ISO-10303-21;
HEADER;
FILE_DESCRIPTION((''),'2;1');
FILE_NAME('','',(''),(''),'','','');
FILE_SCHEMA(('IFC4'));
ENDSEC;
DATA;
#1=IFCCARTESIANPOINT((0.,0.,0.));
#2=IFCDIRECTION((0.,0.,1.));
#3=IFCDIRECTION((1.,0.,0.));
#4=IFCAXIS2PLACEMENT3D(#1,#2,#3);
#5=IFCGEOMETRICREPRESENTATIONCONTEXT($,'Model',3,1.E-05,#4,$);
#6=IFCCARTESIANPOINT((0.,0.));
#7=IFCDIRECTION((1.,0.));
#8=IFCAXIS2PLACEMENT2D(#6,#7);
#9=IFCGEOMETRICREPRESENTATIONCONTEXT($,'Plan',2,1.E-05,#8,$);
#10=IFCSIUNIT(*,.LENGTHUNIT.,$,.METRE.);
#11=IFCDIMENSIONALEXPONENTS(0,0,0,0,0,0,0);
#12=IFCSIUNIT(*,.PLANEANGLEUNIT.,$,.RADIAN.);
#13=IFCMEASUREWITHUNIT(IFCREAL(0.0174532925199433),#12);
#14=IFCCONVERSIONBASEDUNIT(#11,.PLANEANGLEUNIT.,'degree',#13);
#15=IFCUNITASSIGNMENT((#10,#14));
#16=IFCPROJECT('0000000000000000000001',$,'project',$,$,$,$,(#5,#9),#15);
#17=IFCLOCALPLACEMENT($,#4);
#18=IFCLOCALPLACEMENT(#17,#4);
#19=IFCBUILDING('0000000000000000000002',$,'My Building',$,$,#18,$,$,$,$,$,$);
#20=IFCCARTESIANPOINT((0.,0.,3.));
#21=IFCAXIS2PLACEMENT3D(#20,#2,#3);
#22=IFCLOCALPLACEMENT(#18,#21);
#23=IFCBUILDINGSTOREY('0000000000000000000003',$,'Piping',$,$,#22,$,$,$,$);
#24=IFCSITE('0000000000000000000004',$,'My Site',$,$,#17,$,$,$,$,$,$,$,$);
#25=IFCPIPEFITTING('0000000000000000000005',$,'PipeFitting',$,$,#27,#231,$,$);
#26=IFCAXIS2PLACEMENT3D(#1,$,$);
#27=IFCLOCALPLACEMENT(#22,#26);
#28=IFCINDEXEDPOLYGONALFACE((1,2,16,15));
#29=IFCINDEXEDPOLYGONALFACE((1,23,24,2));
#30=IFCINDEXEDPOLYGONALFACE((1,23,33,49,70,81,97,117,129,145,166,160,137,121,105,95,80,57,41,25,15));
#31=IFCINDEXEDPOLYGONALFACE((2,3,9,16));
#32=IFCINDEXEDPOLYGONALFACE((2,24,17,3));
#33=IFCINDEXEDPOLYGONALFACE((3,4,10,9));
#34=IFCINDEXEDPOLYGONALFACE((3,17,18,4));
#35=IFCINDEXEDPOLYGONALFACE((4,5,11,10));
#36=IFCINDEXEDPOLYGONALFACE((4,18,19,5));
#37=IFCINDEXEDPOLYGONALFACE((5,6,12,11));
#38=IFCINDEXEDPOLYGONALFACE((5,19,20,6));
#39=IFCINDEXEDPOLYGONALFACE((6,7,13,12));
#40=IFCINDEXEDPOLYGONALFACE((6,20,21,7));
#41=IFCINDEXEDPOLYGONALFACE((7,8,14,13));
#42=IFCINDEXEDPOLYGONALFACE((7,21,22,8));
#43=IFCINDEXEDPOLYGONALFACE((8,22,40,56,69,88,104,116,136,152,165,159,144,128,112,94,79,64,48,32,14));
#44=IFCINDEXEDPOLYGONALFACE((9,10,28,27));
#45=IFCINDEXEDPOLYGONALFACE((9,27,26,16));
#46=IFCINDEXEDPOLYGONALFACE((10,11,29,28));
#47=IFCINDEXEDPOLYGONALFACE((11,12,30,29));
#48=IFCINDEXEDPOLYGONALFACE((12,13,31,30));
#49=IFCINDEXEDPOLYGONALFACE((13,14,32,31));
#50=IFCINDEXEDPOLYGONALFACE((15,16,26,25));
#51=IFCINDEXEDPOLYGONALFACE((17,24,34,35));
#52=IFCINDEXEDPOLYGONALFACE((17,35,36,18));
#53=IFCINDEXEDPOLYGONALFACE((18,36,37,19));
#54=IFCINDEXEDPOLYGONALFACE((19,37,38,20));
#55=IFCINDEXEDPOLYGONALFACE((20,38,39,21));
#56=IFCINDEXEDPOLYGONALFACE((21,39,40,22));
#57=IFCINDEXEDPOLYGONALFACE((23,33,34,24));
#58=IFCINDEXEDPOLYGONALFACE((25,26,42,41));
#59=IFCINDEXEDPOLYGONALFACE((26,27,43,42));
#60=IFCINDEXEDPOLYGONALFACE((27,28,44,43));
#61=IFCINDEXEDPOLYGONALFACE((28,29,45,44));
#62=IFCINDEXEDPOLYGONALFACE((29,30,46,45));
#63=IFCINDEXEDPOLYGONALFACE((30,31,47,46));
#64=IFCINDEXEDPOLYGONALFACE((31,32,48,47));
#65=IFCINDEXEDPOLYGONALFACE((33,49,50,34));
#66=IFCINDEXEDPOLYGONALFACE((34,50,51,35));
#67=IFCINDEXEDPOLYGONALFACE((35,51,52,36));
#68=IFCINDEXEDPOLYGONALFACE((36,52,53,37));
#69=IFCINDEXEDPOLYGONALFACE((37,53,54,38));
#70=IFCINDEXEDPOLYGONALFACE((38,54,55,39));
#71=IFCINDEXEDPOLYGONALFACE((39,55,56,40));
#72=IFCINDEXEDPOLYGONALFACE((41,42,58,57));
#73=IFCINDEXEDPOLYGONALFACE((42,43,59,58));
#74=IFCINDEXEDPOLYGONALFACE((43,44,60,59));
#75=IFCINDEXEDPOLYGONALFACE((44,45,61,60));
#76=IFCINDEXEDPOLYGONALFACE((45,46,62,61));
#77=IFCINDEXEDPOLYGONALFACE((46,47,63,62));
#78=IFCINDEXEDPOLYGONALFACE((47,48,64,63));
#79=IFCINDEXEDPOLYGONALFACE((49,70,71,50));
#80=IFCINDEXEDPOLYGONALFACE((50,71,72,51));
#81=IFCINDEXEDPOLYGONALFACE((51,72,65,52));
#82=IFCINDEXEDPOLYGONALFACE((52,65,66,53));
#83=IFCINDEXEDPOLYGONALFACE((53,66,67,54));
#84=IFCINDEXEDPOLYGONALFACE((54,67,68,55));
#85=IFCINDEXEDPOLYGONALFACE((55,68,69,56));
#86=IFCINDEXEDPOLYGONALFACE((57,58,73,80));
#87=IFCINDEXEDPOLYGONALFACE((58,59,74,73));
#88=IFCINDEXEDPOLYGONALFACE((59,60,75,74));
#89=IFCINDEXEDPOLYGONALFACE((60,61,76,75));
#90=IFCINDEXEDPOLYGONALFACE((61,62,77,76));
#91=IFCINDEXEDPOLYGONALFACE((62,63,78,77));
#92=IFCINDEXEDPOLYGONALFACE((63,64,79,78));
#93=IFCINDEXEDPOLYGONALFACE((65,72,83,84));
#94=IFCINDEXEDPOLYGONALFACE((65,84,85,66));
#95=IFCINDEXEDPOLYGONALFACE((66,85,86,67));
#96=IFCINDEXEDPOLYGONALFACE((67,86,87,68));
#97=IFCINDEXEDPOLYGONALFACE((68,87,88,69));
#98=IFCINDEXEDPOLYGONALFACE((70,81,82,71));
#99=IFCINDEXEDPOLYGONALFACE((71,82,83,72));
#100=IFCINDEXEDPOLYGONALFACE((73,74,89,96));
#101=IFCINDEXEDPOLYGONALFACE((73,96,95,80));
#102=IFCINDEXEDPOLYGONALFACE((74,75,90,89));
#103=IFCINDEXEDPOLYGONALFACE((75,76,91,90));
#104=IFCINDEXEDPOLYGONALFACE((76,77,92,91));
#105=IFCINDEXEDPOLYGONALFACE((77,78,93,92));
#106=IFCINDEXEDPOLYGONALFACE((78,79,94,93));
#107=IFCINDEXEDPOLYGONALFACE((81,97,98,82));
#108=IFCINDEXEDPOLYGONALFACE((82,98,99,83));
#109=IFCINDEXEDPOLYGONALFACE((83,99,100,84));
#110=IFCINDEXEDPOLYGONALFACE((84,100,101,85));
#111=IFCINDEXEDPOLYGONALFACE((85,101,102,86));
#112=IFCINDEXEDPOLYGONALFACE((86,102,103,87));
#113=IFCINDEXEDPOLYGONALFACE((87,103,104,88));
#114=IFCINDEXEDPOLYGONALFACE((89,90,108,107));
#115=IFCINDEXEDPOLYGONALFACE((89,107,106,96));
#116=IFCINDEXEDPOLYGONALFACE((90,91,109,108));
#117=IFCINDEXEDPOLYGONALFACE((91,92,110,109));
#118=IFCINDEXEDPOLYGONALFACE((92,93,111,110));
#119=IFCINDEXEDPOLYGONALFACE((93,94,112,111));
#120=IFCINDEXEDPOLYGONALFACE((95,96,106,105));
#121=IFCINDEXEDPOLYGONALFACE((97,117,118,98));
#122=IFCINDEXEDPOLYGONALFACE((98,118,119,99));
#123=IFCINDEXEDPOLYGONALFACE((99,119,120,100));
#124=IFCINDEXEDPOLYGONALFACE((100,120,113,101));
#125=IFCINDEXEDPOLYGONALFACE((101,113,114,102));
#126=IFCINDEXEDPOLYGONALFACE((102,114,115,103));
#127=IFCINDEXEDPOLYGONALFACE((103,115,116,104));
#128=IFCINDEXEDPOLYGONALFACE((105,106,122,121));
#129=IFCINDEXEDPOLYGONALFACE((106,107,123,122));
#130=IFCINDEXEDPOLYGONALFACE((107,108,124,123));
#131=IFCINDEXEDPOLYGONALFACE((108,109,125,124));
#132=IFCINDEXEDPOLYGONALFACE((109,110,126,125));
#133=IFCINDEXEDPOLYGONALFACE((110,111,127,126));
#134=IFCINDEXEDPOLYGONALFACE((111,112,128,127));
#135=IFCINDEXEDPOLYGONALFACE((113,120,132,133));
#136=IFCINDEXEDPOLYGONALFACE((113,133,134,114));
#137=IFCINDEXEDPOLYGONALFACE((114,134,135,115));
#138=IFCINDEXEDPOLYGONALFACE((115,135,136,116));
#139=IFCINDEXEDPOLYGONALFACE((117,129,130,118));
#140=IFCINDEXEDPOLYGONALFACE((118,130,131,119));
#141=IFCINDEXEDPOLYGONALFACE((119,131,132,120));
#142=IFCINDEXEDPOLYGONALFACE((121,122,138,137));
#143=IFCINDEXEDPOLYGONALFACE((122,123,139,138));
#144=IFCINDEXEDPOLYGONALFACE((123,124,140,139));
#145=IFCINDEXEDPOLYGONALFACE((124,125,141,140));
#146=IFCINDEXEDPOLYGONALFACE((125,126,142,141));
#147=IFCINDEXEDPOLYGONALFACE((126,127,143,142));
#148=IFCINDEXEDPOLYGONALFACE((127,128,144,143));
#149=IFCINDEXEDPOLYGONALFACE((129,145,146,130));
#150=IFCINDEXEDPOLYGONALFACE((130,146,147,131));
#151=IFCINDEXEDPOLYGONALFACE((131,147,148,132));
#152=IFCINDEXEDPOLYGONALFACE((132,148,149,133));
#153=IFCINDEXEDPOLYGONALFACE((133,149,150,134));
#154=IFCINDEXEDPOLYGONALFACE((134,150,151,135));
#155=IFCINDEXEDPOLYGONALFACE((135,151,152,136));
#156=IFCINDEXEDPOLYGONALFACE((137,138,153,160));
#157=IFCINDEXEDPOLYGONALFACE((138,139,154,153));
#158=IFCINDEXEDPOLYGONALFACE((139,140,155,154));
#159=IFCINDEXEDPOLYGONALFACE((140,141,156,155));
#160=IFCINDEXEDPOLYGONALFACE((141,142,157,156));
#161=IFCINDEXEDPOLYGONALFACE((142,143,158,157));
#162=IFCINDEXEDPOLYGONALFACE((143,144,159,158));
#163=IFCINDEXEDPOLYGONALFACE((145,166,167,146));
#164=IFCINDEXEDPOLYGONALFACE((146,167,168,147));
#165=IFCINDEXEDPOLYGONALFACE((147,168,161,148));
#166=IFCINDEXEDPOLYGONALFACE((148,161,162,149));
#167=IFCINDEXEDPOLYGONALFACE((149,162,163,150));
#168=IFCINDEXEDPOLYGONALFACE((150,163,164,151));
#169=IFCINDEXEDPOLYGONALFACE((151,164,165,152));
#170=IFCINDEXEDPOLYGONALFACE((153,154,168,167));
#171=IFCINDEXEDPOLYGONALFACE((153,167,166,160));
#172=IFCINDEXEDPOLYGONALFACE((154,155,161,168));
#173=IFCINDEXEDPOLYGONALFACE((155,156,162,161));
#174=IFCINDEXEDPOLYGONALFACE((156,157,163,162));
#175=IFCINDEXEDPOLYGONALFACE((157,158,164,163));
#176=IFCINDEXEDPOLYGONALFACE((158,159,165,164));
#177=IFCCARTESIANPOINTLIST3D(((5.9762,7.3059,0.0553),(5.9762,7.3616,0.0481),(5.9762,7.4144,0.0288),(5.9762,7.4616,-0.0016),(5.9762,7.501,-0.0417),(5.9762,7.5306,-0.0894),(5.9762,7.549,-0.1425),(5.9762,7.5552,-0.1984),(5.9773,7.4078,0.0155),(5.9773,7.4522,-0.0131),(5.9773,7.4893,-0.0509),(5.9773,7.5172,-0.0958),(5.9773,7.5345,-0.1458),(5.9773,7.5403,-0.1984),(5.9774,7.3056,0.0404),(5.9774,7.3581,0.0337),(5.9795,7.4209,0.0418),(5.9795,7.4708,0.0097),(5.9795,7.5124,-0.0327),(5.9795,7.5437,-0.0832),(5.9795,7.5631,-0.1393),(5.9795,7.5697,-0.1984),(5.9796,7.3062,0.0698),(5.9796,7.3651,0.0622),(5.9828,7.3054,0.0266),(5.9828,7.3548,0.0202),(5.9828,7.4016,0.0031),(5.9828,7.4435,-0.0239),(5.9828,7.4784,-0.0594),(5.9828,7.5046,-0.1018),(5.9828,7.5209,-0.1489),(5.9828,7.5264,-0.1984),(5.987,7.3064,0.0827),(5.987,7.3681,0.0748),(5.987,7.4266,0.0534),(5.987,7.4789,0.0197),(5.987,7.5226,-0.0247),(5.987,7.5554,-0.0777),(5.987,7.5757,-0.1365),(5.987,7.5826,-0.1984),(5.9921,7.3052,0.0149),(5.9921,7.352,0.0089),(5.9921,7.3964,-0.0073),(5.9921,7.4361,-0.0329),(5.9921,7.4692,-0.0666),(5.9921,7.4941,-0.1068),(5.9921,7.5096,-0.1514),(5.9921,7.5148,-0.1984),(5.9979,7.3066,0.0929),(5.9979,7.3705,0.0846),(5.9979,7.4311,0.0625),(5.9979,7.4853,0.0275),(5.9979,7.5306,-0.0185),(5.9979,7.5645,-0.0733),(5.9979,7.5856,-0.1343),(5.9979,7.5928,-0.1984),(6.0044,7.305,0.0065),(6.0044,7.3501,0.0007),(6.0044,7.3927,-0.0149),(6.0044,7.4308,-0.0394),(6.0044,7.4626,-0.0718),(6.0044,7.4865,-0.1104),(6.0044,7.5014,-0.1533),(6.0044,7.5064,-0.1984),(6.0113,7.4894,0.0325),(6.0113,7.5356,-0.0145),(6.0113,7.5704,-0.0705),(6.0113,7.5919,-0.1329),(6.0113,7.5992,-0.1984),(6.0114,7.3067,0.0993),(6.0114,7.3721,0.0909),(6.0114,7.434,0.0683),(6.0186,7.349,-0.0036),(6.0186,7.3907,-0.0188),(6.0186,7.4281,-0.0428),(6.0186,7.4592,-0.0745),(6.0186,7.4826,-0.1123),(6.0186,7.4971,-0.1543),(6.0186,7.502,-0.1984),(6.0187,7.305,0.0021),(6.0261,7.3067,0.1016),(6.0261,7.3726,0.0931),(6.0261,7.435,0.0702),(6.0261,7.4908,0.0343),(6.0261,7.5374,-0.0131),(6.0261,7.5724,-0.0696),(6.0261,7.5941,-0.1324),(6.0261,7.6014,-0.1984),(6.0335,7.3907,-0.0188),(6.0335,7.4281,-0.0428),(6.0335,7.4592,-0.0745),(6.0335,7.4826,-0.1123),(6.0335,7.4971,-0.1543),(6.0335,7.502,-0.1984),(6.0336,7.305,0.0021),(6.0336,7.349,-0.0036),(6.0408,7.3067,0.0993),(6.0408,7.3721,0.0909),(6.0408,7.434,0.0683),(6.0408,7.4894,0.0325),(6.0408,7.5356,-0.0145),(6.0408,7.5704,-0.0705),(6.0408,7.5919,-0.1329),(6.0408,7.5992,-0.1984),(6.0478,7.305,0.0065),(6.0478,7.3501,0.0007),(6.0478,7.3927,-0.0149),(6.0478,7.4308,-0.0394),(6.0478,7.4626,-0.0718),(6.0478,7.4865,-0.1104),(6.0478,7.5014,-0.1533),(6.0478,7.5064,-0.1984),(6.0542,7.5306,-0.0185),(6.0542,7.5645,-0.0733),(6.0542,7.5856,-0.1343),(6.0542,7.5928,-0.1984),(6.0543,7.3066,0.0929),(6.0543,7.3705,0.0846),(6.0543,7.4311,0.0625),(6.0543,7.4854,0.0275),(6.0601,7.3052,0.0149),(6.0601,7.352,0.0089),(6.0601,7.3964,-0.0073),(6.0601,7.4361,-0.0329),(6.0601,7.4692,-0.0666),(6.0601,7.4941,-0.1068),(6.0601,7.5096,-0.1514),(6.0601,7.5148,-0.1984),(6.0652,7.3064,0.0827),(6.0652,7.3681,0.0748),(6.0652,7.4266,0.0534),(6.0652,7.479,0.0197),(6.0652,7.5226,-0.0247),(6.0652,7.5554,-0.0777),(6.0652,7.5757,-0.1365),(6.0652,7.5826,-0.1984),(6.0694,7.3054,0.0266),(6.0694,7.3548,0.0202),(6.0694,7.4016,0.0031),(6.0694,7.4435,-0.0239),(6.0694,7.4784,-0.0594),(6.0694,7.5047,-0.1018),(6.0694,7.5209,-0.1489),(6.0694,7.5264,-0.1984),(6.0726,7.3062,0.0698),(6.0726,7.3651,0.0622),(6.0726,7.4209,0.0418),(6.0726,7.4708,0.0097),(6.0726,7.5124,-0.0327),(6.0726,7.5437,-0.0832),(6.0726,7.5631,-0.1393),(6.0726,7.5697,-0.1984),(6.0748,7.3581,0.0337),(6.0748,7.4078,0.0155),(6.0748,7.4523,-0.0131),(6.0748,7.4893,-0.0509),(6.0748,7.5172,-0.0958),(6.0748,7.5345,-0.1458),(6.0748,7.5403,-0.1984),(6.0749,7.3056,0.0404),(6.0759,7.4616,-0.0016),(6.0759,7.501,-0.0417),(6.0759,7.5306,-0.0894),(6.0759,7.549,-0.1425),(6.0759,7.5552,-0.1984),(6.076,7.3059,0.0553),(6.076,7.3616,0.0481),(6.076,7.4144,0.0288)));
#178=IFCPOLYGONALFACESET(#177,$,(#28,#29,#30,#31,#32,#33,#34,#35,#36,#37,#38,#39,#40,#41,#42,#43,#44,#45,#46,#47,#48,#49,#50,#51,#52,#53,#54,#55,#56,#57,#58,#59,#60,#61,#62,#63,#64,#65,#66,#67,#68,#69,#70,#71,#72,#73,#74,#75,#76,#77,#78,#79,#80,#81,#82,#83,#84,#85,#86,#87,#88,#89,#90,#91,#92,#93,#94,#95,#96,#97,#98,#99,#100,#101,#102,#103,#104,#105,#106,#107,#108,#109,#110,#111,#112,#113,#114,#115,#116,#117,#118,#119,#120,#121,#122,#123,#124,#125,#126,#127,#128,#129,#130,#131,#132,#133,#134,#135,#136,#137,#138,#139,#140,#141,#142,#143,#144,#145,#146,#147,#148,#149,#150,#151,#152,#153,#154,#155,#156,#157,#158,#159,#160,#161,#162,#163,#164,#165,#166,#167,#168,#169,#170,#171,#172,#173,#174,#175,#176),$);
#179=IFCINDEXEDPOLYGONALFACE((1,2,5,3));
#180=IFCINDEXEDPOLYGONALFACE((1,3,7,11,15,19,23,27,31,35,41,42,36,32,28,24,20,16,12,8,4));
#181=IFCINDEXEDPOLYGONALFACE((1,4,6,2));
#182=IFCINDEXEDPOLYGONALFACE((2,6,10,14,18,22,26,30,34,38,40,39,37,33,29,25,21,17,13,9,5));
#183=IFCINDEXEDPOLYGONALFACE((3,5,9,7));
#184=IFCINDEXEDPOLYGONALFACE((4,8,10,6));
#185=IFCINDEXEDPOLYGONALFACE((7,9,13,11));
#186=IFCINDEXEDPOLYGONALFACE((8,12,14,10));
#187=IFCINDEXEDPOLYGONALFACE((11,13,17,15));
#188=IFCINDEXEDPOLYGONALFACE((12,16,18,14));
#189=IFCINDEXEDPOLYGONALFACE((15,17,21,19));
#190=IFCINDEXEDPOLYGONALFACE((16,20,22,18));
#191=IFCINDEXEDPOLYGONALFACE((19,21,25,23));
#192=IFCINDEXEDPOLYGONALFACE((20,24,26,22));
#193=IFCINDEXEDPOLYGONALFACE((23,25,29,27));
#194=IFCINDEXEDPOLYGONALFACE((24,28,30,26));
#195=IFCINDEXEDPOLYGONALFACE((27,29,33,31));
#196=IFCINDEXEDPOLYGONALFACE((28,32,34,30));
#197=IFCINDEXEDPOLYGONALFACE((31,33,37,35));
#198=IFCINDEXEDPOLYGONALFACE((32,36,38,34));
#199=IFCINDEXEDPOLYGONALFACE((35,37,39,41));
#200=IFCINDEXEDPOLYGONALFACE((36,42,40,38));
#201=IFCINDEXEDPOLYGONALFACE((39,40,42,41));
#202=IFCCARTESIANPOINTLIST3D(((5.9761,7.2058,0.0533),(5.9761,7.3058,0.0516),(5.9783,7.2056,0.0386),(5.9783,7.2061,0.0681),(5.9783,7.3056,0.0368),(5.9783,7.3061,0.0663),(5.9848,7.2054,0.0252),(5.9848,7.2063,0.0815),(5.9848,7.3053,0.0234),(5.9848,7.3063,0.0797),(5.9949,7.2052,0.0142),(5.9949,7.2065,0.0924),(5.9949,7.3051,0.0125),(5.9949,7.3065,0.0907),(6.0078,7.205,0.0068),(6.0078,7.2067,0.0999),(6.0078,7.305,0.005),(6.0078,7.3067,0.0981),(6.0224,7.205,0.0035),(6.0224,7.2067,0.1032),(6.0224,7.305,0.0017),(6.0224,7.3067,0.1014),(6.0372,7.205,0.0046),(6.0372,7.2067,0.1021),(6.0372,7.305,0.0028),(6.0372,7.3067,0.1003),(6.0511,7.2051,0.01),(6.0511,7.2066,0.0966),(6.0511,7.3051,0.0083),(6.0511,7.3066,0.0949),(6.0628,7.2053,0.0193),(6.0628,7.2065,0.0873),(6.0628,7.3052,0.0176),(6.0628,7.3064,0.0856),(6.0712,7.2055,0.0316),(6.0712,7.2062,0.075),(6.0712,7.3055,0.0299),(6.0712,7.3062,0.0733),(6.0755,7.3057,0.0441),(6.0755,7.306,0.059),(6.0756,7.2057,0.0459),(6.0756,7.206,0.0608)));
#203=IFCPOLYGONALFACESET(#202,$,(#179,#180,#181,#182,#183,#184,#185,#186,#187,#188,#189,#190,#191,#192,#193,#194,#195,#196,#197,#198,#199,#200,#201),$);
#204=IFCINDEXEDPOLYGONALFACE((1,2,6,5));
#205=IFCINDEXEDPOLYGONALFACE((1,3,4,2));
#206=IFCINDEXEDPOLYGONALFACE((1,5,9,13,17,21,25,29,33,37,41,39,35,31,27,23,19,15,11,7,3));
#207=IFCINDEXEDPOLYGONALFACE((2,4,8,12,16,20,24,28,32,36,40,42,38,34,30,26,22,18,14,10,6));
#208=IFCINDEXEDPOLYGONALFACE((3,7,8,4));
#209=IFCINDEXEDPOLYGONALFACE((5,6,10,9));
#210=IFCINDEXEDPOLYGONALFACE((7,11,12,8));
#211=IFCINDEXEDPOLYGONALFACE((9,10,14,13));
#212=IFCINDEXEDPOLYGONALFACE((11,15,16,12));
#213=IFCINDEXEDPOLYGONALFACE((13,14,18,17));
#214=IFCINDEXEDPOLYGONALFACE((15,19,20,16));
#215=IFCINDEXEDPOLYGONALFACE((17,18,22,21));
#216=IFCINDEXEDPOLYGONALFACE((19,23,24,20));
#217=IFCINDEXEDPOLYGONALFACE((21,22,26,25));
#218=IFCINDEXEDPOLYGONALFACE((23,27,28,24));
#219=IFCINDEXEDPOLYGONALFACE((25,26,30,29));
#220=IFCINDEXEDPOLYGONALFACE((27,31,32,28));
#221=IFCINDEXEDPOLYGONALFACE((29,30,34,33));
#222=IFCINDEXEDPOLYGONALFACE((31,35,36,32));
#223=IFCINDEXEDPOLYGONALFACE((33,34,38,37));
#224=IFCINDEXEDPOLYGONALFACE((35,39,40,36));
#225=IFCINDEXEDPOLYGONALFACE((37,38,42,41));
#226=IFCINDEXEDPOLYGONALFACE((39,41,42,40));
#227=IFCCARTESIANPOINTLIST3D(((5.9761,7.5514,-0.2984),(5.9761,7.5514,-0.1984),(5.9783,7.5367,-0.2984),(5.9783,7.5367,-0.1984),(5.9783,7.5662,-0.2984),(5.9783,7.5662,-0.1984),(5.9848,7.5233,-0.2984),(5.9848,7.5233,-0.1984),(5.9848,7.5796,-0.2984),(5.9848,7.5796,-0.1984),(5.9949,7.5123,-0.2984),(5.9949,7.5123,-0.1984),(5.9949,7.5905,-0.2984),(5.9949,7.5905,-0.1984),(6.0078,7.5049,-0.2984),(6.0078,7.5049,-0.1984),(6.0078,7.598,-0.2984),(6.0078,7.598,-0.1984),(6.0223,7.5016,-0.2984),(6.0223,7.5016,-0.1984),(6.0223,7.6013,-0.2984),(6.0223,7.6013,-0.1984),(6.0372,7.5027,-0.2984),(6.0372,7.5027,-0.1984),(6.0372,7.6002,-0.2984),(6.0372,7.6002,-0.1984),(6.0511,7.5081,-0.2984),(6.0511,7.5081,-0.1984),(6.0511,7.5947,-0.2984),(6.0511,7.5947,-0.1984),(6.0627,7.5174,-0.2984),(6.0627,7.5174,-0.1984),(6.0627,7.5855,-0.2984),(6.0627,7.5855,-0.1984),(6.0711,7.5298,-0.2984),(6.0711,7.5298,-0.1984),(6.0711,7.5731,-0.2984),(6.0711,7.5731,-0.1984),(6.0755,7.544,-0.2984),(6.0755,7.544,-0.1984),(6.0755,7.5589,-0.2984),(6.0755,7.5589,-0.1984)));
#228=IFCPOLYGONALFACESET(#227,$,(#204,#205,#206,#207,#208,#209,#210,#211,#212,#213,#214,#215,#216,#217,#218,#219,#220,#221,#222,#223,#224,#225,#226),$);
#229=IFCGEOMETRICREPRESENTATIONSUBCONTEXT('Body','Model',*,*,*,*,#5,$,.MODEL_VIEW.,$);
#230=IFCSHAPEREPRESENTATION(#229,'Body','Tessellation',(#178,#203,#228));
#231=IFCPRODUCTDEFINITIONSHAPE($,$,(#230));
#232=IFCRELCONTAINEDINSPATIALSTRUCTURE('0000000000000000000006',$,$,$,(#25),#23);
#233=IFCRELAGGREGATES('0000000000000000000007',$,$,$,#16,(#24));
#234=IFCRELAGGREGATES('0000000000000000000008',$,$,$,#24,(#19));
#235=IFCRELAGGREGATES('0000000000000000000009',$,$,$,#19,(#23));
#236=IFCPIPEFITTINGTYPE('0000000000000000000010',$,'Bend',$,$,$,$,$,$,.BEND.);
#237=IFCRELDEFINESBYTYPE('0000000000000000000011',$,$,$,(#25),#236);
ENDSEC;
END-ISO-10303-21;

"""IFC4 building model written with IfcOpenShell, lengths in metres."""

from ifc_helpers import new_model, entity, si_unit, converted_unit, frame, origin_with_axes, origin_2d_with_axis, place, context, subcontext, project, spatial, circle, extrude, source, transform, mapped, type_object, type_shapes, element, save


model = new_model("IFC4")

# Units and contexts
model_context = context("Model", 3, precision=1e-05, world=origin_with_axes())
plan_context = context("Plan", 2, precision=1e-05, world=origin_2d_with_axis())
body_context = subcontext(model_context, "Body", "Model", "MODEL_VIEW")
ifc_project = project(units=[si_unit("LENGTHUNIT", "METRE"), converted_unit("PLANEANGLEUNIT", "degree", entity("IfcReal", 0.0174532925199433), si_unit("PLANEANGLEUNIT", "RADIAN"), dimensions=[0, 0, 0, 0, 0, 0, 0])], contexts=[model_context, plan_context])

# Site, building, storey
site_placement = place(None, origin_with_axes())
site = spatial("IfcSite", under=ifc_project, at=site_placement, Name="My Site")
building_placement = place(site_placement, origin_with_axes())
building = spatial("IfcBuilding", under=site, at=building_placement, Name="My Building")
storey_placement = place(building_placement, frame((0.0, 0.0, 3.0), z_axis=(0.0, 0.0, 1.0), x_axis=(1.0, 0.0, 0.0)))
storey = spatial("IfcBuildingStorey", under=building, at=storey_placement, Name="Piping")

# Pipe fitting
pipe_fitting_type_1 = type_object("IfcPipeFittingType", Name="Bend", PredefinedType="BEND")
shared_shape_1 = source(origin_with_axes(), body_context, "Body", "SolidModel", [
    entity("IfcSweptDiskSolid", entity("IfcIndexedPolyCurve", entity("IfcCartesianPointList3D", [[0.0, 0.0, 0.1], [0.0, -0.0717, 0.2752], [0.0, -0.2456, 0.35]]), [entity("IfcArcIndex", [1, 2, 3])]), 0.05),
    extrude(circle(Radius=0.05), origin_with_axes(), (0.0, 0.0, 1.0), 0.1),
    extrude(circle(Radius=0.05), frame((0.0, -0.2456, 0.35), z_axis=(0.0, -0.999846, 0.017575), x_axis=(1.0, 0.0, 0.0)), (0.0, 0.0, 1.0), 0.1),
])
type_shapes(pipe_fitting_type_1, [shared_shape_1])
for number, where, z_axis, x_axis, name in (
    (1, (6.0261, 7.2059, 0.0533), (-0.000099, 0.999846, -0.017575), (-1.0, -0.000099, 0.0), "PipeFitting"),
):
    element("IfcPipeFitting", number, at=place(storey_placement, frame(where, z_axis=z_axis, x_axis=x_axis)), inside=storey, type_object=pipe_fitting_type_1, Name=name, context=body_context, shape_type="MappedRepresentation", body=[
        mapped(shared_shape_1, transform((0.0, 0.0, 0.0), x_axis=(1.0, 0.0, 0.0), y_axis=(0.0, 1.0, 0.0), z_axis=(0.0, 0.0, 1.0), scale=1.0)),
    ])

save(model, "model.ifc")
